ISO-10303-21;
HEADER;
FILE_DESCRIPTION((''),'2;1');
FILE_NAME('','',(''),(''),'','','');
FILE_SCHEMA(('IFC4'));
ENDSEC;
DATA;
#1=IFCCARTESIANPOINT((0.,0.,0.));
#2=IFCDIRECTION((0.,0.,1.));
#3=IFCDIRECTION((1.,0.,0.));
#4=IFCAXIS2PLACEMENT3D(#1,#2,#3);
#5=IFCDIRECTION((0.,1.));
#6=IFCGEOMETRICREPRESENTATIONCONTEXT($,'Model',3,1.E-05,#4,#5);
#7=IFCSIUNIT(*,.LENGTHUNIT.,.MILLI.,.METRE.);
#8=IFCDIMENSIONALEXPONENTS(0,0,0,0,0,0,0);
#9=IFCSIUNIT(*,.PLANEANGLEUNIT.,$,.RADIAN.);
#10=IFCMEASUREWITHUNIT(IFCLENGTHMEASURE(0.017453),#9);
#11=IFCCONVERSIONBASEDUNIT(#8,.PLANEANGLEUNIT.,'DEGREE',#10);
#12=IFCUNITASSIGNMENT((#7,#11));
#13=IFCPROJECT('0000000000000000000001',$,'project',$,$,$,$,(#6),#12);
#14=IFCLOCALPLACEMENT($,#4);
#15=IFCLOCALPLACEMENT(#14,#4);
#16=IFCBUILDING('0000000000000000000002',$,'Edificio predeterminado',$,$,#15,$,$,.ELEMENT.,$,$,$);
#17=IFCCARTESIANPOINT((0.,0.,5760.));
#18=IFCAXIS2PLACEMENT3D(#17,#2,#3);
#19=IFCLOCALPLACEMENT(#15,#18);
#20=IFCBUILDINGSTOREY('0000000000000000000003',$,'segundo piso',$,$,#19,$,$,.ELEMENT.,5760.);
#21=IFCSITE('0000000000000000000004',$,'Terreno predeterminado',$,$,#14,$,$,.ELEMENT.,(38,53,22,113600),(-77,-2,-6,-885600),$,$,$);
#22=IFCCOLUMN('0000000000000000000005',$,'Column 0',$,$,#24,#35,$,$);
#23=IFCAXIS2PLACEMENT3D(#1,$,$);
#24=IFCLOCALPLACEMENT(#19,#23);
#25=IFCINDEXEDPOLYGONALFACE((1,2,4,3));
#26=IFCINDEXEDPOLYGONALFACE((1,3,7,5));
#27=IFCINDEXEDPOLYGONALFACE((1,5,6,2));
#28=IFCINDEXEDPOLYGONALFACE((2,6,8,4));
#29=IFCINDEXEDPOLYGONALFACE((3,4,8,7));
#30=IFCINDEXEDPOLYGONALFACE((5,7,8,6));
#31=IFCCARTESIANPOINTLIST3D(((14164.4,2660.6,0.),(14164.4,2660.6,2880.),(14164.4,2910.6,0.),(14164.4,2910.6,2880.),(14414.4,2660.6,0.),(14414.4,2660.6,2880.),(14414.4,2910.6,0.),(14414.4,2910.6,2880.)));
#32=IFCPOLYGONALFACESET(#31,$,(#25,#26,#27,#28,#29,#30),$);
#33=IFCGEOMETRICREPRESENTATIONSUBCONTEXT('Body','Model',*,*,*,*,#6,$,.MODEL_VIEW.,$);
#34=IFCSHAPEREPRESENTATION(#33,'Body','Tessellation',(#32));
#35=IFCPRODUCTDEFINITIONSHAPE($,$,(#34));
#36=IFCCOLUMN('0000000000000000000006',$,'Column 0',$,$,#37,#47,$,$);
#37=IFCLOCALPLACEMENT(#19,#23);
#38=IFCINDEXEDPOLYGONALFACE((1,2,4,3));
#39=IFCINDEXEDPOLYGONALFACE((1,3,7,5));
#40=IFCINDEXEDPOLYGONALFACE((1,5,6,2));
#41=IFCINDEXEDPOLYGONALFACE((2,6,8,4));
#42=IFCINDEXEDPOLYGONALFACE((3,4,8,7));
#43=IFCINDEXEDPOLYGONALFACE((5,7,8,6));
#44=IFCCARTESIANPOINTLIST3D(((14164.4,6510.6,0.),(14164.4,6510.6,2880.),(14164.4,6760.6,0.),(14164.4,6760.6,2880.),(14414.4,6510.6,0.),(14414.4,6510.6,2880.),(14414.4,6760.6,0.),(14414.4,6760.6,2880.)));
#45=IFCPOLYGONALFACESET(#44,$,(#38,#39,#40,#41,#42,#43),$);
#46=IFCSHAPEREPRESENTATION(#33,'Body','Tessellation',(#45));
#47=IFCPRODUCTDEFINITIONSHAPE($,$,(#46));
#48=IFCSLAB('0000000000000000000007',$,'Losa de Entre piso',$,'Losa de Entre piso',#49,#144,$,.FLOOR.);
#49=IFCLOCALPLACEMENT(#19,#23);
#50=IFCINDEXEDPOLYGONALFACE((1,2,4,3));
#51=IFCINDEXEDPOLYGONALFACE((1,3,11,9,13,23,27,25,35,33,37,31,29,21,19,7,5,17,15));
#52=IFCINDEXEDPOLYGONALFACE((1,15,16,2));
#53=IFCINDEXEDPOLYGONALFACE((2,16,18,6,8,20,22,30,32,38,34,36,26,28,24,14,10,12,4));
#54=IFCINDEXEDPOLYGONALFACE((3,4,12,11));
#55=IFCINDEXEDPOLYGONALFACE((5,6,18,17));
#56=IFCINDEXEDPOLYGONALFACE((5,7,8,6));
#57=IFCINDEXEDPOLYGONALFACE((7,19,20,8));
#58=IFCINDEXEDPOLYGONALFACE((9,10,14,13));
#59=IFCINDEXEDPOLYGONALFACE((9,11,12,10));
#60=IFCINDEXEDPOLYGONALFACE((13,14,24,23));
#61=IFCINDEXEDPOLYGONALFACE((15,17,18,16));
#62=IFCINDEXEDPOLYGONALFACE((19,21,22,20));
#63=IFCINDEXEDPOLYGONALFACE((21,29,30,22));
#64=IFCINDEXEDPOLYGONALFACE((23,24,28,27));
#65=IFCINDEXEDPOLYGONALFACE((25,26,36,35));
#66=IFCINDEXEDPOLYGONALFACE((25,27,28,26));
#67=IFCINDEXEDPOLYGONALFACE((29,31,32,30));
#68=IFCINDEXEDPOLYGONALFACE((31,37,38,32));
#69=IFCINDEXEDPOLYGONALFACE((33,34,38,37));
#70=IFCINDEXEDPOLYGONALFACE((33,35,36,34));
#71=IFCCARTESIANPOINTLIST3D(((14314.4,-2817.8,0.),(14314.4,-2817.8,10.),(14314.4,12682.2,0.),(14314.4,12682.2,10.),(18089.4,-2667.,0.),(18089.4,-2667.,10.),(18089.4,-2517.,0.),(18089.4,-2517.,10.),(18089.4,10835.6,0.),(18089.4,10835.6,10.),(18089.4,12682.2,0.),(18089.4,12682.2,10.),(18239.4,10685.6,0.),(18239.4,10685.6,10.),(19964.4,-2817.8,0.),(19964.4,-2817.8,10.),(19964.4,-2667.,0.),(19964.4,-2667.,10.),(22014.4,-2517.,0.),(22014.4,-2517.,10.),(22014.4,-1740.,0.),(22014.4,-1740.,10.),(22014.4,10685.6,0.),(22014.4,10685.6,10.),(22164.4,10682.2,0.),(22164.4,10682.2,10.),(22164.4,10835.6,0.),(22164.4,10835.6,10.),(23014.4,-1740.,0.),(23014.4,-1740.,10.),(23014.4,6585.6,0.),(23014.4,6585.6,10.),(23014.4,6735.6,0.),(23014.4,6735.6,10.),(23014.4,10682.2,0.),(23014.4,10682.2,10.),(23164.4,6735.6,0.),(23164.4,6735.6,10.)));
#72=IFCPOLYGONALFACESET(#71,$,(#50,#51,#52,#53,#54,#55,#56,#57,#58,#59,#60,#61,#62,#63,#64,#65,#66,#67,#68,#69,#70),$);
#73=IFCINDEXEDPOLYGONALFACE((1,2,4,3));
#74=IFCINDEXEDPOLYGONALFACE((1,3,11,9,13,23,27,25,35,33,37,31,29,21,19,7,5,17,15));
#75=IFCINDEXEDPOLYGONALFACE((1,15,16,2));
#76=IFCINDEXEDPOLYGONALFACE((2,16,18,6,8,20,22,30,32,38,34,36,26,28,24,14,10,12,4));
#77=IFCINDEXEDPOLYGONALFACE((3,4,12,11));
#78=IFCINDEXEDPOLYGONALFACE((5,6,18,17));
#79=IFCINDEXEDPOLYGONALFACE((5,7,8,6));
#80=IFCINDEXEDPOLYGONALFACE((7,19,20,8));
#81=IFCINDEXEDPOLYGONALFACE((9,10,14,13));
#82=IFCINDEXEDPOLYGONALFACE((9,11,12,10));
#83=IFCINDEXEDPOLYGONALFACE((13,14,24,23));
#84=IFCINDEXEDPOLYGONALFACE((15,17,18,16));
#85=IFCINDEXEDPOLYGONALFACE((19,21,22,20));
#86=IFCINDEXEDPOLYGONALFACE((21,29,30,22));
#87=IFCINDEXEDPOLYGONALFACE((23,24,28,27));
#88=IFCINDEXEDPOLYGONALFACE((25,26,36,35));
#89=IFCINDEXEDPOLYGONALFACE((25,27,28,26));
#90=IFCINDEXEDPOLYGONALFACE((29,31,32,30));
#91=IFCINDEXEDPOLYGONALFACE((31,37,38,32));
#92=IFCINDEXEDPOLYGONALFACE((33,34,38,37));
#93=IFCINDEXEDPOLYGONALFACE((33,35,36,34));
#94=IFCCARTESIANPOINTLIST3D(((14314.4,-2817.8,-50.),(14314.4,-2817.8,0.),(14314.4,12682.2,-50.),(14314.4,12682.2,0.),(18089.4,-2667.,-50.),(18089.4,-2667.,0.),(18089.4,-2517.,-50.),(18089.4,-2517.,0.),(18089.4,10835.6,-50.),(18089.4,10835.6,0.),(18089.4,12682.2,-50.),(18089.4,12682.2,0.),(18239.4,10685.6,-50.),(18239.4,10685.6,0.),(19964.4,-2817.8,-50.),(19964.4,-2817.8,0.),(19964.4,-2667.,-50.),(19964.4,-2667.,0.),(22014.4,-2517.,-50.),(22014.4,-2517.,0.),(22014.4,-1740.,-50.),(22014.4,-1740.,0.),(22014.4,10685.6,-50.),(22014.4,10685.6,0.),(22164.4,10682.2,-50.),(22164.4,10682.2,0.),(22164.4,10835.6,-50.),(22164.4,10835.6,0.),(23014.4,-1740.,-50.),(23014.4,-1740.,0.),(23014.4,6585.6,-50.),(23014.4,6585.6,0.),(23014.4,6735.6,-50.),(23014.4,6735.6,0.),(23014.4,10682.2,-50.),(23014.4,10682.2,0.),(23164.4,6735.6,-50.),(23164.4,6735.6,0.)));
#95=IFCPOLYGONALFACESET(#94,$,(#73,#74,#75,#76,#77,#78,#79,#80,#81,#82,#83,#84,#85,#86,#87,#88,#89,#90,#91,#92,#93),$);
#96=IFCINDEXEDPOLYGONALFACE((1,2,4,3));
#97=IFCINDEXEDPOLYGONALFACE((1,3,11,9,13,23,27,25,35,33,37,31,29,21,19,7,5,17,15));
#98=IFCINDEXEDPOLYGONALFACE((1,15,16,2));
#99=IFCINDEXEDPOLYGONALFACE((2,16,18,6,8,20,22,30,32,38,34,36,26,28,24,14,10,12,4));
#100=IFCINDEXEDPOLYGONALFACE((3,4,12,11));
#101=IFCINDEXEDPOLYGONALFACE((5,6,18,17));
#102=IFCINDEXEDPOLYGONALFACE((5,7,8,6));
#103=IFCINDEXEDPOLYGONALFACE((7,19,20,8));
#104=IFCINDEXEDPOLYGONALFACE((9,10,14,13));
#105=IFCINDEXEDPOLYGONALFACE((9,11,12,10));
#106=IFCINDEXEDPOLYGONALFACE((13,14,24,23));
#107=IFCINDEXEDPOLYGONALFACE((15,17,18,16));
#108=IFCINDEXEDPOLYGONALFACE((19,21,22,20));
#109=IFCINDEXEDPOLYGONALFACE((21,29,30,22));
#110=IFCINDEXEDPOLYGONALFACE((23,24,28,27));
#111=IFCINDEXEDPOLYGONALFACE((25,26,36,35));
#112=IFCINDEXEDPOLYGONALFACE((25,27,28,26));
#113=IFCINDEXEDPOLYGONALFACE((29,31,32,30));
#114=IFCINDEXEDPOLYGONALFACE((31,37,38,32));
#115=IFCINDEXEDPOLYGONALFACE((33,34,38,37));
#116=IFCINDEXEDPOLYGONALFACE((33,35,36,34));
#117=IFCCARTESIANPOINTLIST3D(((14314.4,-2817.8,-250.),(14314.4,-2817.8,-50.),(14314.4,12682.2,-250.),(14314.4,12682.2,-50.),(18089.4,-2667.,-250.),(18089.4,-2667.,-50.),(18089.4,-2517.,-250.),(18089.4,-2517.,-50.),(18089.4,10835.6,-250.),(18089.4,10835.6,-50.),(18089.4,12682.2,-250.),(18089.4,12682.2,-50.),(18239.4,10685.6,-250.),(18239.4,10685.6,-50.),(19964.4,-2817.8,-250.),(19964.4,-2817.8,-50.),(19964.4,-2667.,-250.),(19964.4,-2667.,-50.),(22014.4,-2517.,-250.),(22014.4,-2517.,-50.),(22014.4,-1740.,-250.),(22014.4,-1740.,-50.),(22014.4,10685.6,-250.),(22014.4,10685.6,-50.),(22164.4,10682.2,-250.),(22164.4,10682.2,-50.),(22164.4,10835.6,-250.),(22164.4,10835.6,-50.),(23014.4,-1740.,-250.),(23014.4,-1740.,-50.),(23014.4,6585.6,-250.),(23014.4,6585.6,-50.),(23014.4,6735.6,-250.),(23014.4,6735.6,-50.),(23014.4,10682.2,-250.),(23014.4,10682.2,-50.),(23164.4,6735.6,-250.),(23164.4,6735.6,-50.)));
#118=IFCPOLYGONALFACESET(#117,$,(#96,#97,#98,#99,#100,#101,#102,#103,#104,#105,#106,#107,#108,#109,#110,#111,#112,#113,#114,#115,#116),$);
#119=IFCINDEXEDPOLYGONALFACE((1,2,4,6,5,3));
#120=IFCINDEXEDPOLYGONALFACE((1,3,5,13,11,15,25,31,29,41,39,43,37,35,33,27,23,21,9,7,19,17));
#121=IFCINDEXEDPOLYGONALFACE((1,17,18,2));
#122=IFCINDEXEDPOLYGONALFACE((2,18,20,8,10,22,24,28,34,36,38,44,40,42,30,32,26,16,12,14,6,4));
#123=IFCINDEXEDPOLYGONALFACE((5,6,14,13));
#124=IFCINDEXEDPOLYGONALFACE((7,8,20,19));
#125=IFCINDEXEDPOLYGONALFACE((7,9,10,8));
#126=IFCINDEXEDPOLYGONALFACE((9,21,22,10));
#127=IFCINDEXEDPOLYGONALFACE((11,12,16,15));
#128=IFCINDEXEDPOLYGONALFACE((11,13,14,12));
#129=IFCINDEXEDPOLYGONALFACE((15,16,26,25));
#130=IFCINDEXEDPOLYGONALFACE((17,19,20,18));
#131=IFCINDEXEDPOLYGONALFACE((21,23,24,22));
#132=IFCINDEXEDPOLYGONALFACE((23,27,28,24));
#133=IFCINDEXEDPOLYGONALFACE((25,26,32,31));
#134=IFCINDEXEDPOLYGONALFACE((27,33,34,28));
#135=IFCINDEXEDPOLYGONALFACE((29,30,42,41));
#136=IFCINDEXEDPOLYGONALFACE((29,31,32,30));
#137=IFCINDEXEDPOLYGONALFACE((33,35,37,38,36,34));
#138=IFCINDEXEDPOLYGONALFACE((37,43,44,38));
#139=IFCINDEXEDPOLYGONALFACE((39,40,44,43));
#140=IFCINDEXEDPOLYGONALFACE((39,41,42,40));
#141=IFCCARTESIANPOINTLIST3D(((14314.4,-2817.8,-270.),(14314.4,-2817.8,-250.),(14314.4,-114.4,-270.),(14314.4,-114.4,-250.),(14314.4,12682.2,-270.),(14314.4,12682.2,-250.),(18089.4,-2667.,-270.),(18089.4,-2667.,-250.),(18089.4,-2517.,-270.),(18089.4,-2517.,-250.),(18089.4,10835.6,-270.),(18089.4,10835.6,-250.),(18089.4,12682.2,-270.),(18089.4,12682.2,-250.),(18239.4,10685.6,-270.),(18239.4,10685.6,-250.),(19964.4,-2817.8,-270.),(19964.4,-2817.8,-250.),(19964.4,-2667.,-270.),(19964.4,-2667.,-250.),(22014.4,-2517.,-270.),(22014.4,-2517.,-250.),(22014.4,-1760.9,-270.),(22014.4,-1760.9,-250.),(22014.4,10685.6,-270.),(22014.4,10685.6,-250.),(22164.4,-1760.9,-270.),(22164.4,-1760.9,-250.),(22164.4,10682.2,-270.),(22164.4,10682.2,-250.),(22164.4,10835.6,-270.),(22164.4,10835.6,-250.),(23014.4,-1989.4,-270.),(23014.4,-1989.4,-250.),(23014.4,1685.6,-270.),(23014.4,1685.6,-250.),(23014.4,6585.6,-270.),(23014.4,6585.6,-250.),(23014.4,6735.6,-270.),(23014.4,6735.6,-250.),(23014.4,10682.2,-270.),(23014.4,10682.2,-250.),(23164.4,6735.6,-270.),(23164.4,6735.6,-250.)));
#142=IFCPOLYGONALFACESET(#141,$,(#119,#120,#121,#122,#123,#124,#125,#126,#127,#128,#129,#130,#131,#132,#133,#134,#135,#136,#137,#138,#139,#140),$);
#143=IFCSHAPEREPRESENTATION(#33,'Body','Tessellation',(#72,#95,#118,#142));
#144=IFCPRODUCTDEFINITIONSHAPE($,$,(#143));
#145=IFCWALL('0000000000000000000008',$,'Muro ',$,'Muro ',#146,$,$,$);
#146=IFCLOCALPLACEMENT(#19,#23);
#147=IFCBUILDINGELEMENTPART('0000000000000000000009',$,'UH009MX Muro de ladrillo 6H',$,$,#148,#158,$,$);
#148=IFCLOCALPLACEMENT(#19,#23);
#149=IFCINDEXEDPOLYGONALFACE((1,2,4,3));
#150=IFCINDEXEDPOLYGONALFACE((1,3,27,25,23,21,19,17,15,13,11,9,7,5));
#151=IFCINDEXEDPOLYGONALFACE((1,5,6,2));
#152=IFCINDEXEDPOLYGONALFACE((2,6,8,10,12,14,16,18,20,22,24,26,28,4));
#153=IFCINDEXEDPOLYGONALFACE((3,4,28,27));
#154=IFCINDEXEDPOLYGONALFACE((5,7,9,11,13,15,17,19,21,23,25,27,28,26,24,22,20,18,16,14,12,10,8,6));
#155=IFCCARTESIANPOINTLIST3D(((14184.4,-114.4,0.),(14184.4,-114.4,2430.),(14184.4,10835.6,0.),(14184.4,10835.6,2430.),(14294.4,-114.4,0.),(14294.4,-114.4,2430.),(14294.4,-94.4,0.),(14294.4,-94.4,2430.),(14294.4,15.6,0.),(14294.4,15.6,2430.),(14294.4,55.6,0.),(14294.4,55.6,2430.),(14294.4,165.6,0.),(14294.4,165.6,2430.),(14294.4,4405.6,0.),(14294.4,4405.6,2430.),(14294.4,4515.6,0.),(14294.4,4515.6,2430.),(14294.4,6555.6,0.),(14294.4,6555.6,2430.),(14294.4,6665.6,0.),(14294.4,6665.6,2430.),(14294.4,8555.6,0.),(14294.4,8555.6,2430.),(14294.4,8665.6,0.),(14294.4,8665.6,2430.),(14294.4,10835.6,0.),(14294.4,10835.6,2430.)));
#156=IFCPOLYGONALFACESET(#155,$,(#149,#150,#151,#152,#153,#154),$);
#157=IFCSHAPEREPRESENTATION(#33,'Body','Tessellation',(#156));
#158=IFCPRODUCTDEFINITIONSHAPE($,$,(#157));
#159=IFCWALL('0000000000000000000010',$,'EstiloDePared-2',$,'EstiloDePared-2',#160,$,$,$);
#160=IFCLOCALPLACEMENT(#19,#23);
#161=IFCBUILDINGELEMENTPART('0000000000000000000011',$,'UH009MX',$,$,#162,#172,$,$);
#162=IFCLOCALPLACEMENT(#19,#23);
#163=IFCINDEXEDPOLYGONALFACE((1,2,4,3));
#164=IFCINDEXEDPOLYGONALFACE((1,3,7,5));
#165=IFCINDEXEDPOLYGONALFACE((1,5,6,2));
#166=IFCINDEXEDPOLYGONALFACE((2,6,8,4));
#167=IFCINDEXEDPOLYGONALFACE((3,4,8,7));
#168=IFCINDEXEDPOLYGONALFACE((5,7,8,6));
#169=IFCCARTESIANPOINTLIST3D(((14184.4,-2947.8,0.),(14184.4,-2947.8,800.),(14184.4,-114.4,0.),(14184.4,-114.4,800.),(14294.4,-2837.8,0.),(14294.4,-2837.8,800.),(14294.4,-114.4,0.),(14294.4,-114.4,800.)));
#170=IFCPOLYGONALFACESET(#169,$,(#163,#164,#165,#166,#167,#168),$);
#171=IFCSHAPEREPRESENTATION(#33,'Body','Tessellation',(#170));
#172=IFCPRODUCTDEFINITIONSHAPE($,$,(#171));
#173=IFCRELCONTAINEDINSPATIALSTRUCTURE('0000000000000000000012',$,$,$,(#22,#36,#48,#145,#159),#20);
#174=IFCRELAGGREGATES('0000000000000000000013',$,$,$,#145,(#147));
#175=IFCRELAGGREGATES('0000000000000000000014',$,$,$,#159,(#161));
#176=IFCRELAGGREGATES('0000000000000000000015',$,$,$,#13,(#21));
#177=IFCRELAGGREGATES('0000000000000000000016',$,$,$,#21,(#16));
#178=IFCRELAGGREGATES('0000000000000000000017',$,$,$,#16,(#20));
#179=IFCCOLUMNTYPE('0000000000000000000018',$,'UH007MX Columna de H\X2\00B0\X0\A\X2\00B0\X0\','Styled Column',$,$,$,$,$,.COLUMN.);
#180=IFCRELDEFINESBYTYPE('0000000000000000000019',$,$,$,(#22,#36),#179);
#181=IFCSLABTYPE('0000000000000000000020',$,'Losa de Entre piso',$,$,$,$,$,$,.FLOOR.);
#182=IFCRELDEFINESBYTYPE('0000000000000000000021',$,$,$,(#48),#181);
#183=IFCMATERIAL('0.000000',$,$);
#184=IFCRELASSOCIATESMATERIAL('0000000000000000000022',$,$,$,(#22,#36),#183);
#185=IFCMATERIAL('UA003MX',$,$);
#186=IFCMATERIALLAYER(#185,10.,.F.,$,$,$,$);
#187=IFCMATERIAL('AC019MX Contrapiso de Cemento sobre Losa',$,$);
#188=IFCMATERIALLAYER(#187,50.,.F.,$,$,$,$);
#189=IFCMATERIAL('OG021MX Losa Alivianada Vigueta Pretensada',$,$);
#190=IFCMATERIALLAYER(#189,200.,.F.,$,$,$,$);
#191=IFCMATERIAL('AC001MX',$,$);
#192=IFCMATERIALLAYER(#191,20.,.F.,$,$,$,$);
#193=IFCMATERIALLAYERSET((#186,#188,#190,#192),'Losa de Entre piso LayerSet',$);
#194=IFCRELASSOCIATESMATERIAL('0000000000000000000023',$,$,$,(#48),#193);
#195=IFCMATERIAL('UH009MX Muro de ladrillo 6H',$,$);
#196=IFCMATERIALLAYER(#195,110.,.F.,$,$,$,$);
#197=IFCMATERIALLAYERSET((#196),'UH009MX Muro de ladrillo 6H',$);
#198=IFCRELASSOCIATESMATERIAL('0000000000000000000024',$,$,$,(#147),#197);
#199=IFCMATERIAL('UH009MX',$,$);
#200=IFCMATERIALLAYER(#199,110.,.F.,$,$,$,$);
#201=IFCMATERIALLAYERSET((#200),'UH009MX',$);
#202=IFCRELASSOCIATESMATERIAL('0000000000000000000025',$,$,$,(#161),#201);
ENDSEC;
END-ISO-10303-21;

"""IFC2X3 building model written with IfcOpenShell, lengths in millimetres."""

from ifc_helpers import new_model, entity, si_unit, converted_unit, direction, frame, origin_with_axes, place, context, subcontext, project, spatial, polyline, outline, extrude, material, layer, layer_set, layer_usage, type_object, element, aggregate, save


model = new_model("IFC2X3")

# Units and contexts
model_context = context("Model", 3, precision=1e-05, world=origin_with_axes(), true_north=direction((0.0, 1.0)))
body_context = subcontext(model_context, "Body", "Model", "MODEL_VIEW")
ifc_project = project(units=[si_unit("LENGTHUNIT", "METRE", prefix="MILLI"), converted_unit("PLANEANGLEUNIT", "DEGREE", entity("IfcLengthMeasure", 0.017453), si_unit("PLANEANGLEUNIT", "RADIAN"), dimensions=[0, 0, 0, 0, 0, 0, 0])], contexts=[model_context])

# Site, building, storey
site_placement = place(None, origin_with_axes())
site = spatial("IfcSite", under=ifc_project, at=site_placement, Name="Terreno predeterminado", CompositionType="ELEMENT", RefLatitude=(38, 53, 22, 113600), RefLongitude=(-77, -2, -6, -885600))
building_placement = place(site_placement, origin_with_axes())
building = spatial("IfcBuilding", under=site, at=building_placement, Name="Edificio predeterminado", CompositionType="ELEMENT")
storey_placement = place(building_placement, frame((0.0, 0.0, 5760.0), z_axis=(0.0, 0.0, 1.0), x_axis=(1.0, 0.0, 0.0)))
storey = spatial("IfcBuildingStorey", under=building, at=storey_placement, Name="segundo piso", CompositionType="ELEMENT", Elevation=5760.0)

# Columns
ifc_material_1 = material(Name="0.000000")
column_type = type_object("IfcColumnType", Name="UH007MX Columna de H°A°", Description="Styled Column", PredefinedType="COLUMN")
for number, where, z_axis, x_axis, name in (
    (1, (14289.4, 2785.6, 0.0), (0.0, 0.0, 1.0), (1.0, 0.0, 0.0), "Column 0"),
    (2, (14289.4, 6635.6, 0.0), (0.0, 0.0, 1.0), (1.0, 0.0, 0.0), "Column 0"),
):
    element("IfcColumn", number, at=place(storey_placement, frame(where, z_axis=z_axis, x_axis=x_axis)), inside=storey, type_object=column_type, material=ifc_material_1, Name=name, context=body_context, shape_type="SweptSolid", body=[
        extrude(outline(polyline([(-125.0, -125.0), (125.0, -125.0), (125.0, 125.0), (-125.0, 125.0), (-125.0, -125.0)])), origin_with_axes(), (0.0, 0.0, 1.0), 2880.0),
    ])

# Slab
ifc_material_2 = material(Name="UA003MX")
ifc_layer_1 = layer(ifc_material_2, 10.0, ventilated=False)
ifc_material_3 = material(Name="AC019MX Contrapiso de Cemento sobre Losa")
ifc_layer_2 = layer(ifc_material_3, 50.0, ventilated=False)
ifc_material_4 = material(Name="OG021MX Losa Alivianada Vigueta Pretensada")
ifc_layer_3 = layer(ifc_material_4, 200.0, ventilated=False)
ifc_material_5 = material(Name="AC001MX")
ifc_layer_4 = layer(ifc_material_5, 20.0, ventilated=False)
ifc_layer_set_1 = layer_set([ifc_layer_1, ifc_layer_2, ifc_layer_3, ifc_layer_4], Name="Losa de Entre piso LayerSet")
ifc_layer_usage_1 = layer_usage(ifc_layer_set_1, "AXIS3", "POSITIVE", 0.0)
slab_type = type_object("IfcSlabType", Name="Losa de Entre piso", PredefinedType="FLOOR")
slab_placement = place(storey_placement, frame((0.0, 0.0, -5760.0), z_axis=(0.0, 0.0, 1.0), x_axis=(1.0, 0.0, 0.0)))
element("IfcSlab", 3, at=slab_placement, inside=storey, type_object=slab_type, material=ifc_layer_usage_1, Name="Losa de Entre piso", ObjectType="Losa de Entre piso", PredefinedType="FLOOR", context=body_context, shape_type="SweptSolid", body=[
    extrude(outline(polyline([(0.0, -777.0), (-1000.0, -777.0), (-1000.0, -9102.6), (-1150.0, -9252.6), (-1000.0, -9252.6), (-1000.0, -13199.1), (-150.0, -13199.1), (-150.0, -13352.6), (0.0, -13202.6), (3775.0, -13202.6), (3925.0, -13352.6), (3925.0, -15199.1), (7700.0, -15199.1), (7700.0, 300.9), (2050.0, 300.9), (2050.0, 150.0), (3925.0, 150.0), (3925.0, 0.0), (0.0, 0.0), (0.0, -777.0)])), frame((22014.4, -2517.0, 5760.0), z_axis=(0.0, 0.0, 1.0), x_axis=(-1.0, 0.0, 0.0)), (0.0, 0.0, 1.0), 10.0),
    extrude(outline(polyline([(0.0, -777.0), (-1000.0, -777.0), (-1000.0, -9102.6), (-1150.0, -9252.6), (-1000.0, -9252.6), (-1000.0, -13199.1), (-150.0, -13199.1), (-150.0, -13352.6), (0.0, -13202.6), (3775.0, -13202.6), (3925.0, -13352.6), (3925.0, -15199.1), (7700.0, -15199.1), (7700.0, 300.9), (2050.0, 300.9), (2050.0, 150.0), (3925.0, 150.0), (3925.0, 0.0), (0.0, 0.0), (0.0, -777.0)])), frame((22014.4, -2517.0, 5710.0), z_axis=(0.0, 0.0, 1.0), x_axis=(-1.0, 0.0, 0.0)), (0.0, 0.0, 1.0), 50.0),
    extrude(outline(polyline([(0.0, -777.0), (-1000.0, -777.0), (-1000.0, -9102.6), (-1150.0, -9252.6), (-1000.0, -9252.6), (-1000.0, -13199.1), (-150.0, -13199.1), (-150.0, -13352.6), (0.0, -13202.6), (3775.0, -13202.6), (3925.0, -13352.6), (3925.0, -15199.1), (7700.0, -15199.1), (7700.0, 300.9), (2050.0, 300.9), (2050.0, 150.0), (3925.0, 150.0), (3925.0, 0.0), (0.0, 0.0), (0.0, -777.0)])), frame((22014.4, -2517.0, 5510.0), z_axis=(0.0, 0.0, 1.0), x_axis=(-1.0, 0.0, 0.0)), (0.0, 0.0, 1.0), 200.0),
    extrude(outline(polyline([(-1305.7, 1305.7), (-3975.1, -1363.6), (5073.5, -10412.1), (6985.1, -12323.8), (10980.3, -8328.6), (10873.6, -8221.9), (9547.8, -9547.8), (9441.7, -9441.7), (12217.1, -6666.3), (11682.5, -6131.7), (11788.6, -6025.7), (12551.1, -5586.1), (9952.5, -2987.5), (6487.7, 477.3), (6487.7, 689.4), (6381.6, 583.4), (3591.0, 3374.0), (2990.0, 2773.0), (2881.5, 2881.5), (2881.5, 2669.3), (212.1, 0.0), (0.0, 0.0), (-1305.7, 1305.7)])), frame((18089.4, 10835.6, 5490.0), z_axis=(0.0, 0.0, 1.0), x_axis=(0.707107, -0.707107, 0.0)), (0.0, 0.0, 1.0), 20.0),
])

# Walls, building element parts
wall_1_placement = place(storey_placement, frame((14239.4, 10835.6, 0.0), z_axis=(0.0, 0.0, 1.0), x_axis=(0.0, -1.0, 0.0)))
wall_1 = element("IfcWall", 4, at=wall_1_placement, inside=storey, Name="Muro ", ObjectType="Muro ")
ifc_material_6 = material(Name="UH009MX Muro de ladrillo 6H")
ifc_layer_5 = layer(ifc_material_6, 110.0, ventilated=False)
ifc_layer_set_2 = layer_set([ifc_layer_5], Name="UH009MX Muro de ladrillo 6H")
ifc_layer_usage_2 = layer_usage(ifc_layer_set_2, "AXIS2", "NEGATIVE", -55.0)
building_element_part_1_placement = place(wall_1_placement, origin_with_axes())
building_element_part_1 = element("IfcBuildingElementPart", 5, at=building_element_part_1_placement, material=ifc_layer_usage_2, Name="UH009MX Muro de ladrillo 6H", context=body_context, shape_type="SweptSolid", body=[
    extrude(outline(polyline([(4280.0, 55.0), (6320.0, 55.0), (6430.0, 55.0), (10670.0, 55.0), (10780.0, 55.0), (10820.0, 55.0), (10930.0, 55.0), (10950.0, 55.0), (10950.0, -55.0), (0.0, -55.0), (0.0, 55.0), (2170.0, 55.0), (2280.0, 55.0), (4170.0, 55.0), (4280.0, 55.0)])), origin_with_axes(), (0.0, 0.0, 1.0), 2430.0),
])
aggregate(wall_1, [building_element_part_1])
wall_2_placement = place(storey_placement, frame((14239.4, -2892.8, 0.0), z_axis=(0.0, 0.0, 1.0), x_axis=(0.0, 1.0, 0.0)))
wall_2 = element("IfcWall", 6, at=wall_2_placement, inside=storey, Name="EstiloDePared-2", ObjectType="EstiloDePared-2")
ifc_material_7 = material(Name="UH009MX")
ifc_layer_6 = layer(ifc_material_7, 110.0, ventilated=False)
ifc_layer_set_3 = layer_set([ifc_layer_6], Name="UH009MX")
ifc_layer_usage_3 = layer_usage(ifc_layer_set_3, "AXIS2", "NEGATIVE", -55.0)
building_element_part_2_placement = place(wall_2_placement, origin_with_axes())
building_element_part_2 = element("IfcBuildingElementPart", 7, at=building_element_part_2_placement, material=ifc_layer_usage_3, Name="UH009MX", context=body_context, shape_type="SweptSolid", body=[
    extrude(outline(polyline([(2778.4, 55.0), (2778.4, -55.0), (55.0, -55.0), (-55.0, 55.0), (2778.4, 55.0)])), origin_with_axes(), (0.0, 0.0, 1.0), 800.0),
])
aggregate(wall_2, [building_element_part_2])

save(model, "model.ifc")
